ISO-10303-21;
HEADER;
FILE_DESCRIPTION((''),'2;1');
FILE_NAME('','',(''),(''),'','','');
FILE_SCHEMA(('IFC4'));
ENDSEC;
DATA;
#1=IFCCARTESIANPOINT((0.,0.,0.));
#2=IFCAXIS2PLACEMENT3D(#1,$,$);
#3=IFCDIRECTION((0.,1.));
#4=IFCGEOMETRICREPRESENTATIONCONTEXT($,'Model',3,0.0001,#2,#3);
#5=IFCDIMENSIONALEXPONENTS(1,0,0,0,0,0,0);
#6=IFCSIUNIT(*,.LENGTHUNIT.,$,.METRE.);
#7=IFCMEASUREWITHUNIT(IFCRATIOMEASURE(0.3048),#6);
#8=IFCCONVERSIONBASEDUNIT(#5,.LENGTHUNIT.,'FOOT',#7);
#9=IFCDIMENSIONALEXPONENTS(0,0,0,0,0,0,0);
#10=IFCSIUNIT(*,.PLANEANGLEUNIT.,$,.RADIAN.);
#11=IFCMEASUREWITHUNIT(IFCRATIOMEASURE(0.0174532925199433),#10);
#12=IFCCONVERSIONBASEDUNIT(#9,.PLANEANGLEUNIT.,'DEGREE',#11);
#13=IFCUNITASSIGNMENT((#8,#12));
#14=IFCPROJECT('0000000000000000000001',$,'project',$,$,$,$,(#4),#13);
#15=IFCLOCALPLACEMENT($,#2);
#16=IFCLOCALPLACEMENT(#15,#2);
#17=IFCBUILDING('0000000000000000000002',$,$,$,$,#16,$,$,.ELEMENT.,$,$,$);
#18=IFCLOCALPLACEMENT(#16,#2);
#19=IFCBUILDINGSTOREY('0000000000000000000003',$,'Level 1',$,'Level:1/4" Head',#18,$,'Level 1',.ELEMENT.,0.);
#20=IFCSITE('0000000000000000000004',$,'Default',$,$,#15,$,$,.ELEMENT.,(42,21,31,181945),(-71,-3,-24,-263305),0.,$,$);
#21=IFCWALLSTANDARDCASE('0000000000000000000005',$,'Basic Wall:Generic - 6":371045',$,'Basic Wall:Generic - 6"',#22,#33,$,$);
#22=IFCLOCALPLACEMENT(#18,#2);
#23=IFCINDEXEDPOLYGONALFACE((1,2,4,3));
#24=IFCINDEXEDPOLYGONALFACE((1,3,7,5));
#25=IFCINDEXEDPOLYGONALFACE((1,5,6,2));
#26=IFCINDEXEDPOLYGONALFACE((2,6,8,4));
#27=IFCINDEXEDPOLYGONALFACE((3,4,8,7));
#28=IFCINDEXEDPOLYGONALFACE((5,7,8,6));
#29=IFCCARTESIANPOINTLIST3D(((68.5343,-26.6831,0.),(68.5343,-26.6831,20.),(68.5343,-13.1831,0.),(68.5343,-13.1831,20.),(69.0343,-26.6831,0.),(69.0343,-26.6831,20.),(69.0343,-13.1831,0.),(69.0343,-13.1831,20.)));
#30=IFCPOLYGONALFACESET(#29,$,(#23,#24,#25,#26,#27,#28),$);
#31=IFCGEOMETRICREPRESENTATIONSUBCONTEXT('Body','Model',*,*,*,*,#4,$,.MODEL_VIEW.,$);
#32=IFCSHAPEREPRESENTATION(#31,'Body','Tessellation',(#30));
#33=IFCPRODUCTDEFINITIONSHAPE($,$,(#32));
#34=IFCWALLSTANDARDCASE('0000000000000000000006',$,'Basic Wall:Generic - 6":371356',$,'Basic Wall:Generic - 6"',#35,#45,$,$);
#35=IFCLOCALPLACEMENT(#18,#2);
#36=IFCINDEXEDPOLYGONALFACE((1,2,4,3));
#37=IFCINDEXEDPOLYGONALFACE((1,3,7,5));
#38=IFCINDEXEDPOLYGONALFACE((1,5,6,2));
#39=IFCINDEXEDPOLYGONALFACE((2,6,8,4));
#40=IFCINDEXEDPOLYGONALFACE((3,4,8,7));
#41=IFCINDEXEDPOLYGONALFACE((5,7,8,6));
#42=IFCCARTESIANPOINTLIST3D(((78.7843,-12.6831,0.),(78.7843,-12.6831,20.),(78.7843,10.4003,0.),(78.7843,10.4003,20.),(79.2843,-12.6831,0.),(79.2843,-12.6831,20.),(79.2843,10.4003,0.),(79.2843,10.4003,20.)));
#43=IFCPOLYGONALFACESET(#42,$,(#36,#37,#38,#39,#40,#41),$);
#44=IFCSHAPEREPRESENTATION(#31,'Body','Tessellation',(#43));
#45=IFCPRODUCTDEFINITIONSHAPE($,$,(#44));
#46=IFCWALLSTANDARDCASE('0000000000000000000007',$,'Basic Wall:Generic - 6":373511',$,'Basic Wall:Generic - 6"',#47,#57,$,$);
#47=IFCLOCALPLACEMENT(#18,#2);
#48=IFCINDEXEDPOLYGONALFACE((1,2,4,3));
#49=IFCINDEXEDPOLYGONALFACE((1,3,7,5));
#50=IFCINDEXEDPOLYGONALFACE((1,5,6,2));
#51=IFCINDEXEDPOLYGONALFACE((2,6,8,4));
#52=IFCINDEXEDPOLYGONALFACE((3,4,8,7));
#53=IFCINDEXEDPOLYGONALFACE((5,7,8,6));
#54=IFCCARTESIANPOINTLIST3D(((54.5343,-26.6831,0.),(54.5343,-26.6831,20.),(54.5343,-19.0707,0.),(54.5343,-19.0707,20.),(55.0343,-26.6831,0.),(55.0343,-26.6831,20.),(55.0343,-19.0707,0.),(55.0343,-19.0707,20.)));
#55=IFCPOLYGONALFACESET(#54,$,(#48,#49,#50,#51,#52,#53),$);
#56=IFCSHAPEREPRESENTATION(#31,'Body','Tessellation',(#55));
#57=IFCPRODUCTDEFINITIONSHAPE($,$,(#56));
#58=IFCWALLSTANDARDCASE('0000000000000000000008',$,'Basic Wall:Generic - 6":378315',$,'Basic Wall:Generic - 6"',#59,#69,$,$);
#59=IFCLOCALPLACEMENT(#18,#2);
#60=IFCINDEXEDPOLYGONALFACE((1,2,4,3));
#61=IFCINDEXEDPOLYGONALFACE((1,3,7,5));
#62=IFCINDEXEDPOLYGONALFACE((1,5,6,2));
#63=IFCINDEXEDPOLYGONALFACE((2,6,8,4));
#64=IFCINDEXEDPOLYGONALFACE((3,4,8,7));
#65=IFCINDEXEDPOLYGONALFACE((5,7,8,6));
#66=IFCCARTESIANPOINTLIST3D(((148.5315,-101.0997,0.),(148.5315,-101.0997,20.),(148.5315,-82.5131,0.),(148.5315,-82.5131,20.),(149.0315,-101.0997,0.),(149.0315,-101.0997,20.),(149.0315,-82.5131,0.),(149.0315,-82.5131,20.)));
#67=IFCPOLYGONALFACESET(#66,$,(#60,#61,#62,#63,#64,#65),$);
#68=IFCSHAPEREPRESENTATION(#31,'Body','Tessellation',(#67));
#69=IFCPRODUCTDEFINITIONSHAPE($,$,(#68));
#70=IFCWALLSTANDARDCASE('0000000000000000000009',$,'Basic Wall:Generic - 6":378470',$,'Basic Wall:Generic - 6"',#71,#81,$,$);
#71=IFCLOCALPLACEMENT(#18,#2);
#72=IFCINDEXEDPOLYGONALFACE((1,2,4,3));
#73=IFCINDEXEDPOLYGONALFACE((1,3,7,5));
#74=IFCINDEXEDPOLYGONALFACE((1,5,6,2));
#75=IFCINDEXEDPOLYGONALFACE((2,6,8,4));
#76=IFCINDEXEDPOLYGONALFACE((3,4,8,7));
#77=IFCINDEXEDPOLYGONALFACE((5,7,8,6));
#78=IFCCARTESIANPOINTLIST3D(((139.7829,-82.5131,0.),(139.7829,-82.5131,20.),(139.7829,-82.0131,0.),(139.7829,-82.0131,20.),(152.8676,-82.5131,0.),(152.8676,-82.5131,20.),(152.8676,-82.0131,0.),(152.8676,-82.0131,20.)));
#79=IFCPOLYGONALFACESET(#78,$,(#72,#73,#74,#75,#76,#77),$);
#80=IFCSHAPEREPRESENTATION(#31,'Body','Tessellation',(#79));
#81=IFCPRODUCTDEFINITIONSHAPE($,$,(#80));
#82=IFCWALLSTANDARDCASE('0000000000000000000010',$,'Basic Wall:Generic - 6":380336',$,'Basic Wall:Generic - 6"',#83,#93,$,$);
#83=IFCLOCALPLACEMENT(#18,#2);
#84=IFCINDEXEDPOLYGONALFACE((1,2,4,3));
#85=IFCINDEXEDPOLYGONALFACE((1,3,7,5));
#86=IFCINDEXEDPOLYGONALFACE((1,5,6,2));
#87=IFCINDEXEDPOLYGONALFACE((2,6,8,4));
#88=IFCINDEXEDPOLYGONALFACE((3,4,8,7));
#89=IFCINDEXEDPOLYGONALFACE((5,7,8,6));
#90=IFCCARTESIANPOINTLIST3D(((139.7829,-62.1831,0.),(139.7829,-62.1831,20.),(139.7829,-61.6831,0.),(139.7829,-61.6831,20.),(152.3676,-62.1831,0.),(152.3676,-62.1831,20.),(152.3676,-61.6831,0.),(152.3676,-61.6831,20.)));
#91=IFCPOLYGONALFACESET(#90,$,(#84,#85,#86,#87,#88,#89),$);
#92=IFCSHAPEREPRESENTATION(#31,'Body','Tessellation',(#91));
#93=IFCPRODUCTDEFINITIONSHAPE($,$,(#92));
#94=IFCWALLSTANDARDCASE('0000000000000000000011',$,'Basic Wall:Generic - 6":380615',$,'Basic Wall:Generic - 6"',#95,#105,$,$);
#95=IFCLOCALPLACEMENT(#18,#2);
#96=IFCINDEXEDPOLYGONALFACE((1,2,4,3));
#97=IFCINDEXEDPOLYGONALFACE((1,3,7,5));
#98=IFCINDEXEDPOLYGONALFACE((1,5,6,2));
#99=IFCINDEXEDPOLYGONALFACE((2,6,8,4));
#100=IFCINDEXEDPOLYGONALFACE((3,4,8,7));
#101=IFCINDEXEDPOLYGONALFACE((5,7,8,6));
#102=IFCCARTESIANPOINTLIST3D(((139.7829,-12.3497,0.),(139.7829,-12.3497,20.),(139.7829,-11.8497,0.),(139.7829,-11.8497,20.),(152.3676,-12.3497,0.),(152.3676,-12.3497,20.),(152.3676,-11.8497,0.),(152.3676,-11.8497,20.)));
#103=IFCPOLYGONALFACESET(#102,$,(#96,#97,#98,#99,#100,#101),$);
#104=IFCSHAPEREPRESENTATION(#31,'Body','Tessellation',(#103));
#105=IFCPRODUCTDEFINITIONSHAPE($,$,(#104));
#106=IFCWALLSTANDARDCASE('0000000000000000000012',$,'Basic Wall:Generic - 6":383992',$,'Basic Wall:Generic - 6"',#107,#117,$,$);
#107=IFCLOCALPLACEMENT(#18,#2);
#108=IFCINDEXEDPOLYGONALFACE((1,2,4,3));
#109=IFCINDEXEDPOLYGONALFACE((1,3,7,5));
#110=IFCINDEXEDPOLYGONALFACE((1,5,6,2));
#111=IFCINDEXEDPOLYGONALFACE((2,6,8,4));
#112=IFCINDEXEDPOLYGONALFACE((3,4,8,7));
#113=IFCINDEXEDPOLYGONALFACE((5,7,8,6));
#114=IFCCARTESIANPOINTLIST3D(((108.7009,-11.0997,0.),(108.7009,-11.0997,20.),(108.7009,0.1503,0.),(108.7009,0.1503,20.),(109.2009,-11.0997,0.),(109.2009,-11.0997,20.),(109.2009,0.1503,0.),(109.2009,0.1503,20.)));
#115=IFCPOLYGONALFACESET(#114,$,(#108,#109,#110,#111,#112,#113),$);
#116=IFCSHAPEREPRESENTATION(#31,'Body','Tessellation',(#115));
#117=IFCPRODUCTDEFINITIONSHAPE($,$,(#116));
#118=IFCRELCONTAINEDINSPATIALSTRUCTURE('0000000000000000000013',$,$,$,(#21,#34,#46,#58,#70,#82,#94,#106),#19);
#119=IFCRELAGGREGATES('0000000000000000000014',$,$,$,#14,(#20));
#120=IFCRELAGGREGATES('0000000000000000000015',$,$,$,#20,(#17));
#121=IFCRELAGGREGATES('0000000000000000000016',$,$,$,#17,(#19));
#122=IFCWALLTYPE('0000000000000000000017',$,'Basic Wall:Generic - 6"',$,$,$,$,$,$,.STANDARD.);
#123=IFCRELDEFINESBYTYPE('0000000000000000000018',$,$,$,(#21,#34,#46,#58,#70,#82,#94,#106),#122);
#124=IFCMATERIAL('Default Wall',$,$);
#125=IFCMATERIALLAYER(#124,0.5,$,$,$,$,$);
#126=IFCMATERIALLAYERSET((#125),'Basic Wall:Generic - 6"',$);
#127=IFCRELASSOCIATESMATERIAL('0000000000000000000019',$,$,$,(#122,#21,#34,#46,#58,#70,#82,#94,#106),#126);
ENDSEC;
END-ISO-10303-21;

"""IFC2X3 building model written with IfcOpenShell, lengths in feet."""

from ifc_helpers import new_model, entity, si_unit, converted_unit, direction, frame, frame_2d, origin, place, context, subcontext, project, spatial, rectangle, extrude, material, layer, layer_set, layer_usage, type_object, element, save


model = new_model("IFC2X3")

# Units and contexts
model_context = context("Model", 3, precision=0.0001, world=origin(), true_north=direction((0.0, 1.0)))
body_context = subcontext(model_context, "Body", "Model", "MODEL_VIEW")
ifc_project = project(units=[converted_unit("LENGTHUNIT", "FOOT", entity("IfcRatioMeasure", 0.3048), si_unit("LENGTHUNIT", "METRE"), dimensions=[1, 0, 0, 0, 0, 0, 0]), converted_unit("PLANEANGLEUNIT", "DEGREE", entity("IfcRatioMeasure", 0.0174532925199433), si_unit("PLANEANGLEUNIT", "RADIAN"), dimensions=[0, 0, 0, 0, 0, 0, 0])], contexts=[model_context])

# Site, building, storey
site_placement = place(None, origin())
site = spatial("IfcSite", under=ifc_project, at=site_placement, Name="Default", CompositionType="ELEMENT", RefLatitude=(42, 21, 31, 181945), RefLongitude=(-71, -3, -24, -263305), RefElevation=0.0)
building_placement = place(site_placement, origin())
building = spatial("IfcBuilding", under=site, at=building_placement, CompositionType="ELEMENT")
storey_placement = place(building_placement, origin())
storey = spatial("IfcBuildingStorey", under=building, at=storey_placement, Name="Level 1", ObjectType="Level:1/4\" Head", LongName="Level 1", CompositionType="ELEMENT", Elevation=0.0)

# Walls
ifc_material = material(Name="Default Wall")
ifc_layer_1 = layer(ifc_material, 0.5)
ifc_layer_set_1 = layer_set([ifc_layer_1], Name="Basic Wall:Generic - 6\"")
wall_type_1 = type_object("IfcWallType", Name="Basic Wall:Generic - 6\"", PredefinedType="STANDARD", material=ifc_layer_set_1)
ifc_layer_usage_1 = layer_usage(ifc_layer_set_1, "AXIS2", "NEGATIVE", 0.25)
wall_1_placement = place(storey_placement, frame((68.7843, -13.1831, 0.0), z_axis=(0.0, 0.0, 1.0), x_axis=(0.0, -1.0, 0.0)))
element("IfcWallStandardCase", 1, at=wall_1_placement, inside=storey, type_object=wall_type_1, material=ifc_layer_usage_1, Name="Basic Wall:Generic - 6\":371045", ObjectType="Basic Wall:Generic - 6\"", context=body_context, shape_type="SweptSolid", body=[
    extrude(rectangle(XDim=13.5, YDim=0.5, at=frame_2d((6.75, 0.0), x_axis=(-1.0, 0.0))), origin(), (0.0, 0.0, 1.0), 20.0),
])
ifc_layer_usage_2 = layer_usage(ifc_layer_set_1, "AXIS2", "NEGATIVE", 0.25)
wall_2_placement = place(storey_placement, frame((79.0343, -12.6831, 0.0), z_axis=(0.0, 0.0, 1.0), x_axis=(0.0, 1.0, 0.0)))
element("IfcWallStandardCase", 2, at=wall_2_placement, inside=storey, type_object=wall_type_1, material=ifc_layer_usage_2, Name="Basic Wall:Generic - 6\":371356", ObjectType="Basic Wall:Generic - 6\"", context=body_context, shape_type="SweptSolid", body=[
    extrude(rectangle(XDim=23.0833, YDim=0.5, at=frame_2d((11.5417, 0.0), x_axis=(-1.0, 0.0))), origin(), (0.0, 0.0, 1.0), 20.0),
])
ifc_layer_usage_3 = layer_usage(ifc_layer_set_1, "AXIS2", "NEGATIVE", 0.25)
wall_3_placement = place(storey_placement, frame((54.7843, -19.0707, 0.0), z_axis=(0.0, 0.0, 1.0), x_axis=(0.0, -1.0, 0.0)))
element("IfcWallStandardCase", 3, at=wall_3_placement, inside=storey, type_object=wall_type_1, material=ifc_layer_usage_3, Name="Basic Wall:Generic - 6\":373511", ObjectType="Basic Wall:Generic - 6\"", context=body_context, shape_type="SweptSolid", body=[
    extrude(rectangle(XDim=7.6123, YDim=0.5, at=frame_2d((3.8062, 0.0), x_axis=(-1.0, 0.0))), origin(), (0.0, 0.0, 1.0), 20.0),
])
ifc_layer_usage_4 = layer_usage(ifc_layer_set_1, "AXIS2", "NEGATIVE", 0.25)
wall_4_placement = place(storey_placement, frame((148.7815, -101.0997, 0.0), z_axis=(0.0, 0.0, 1.0), x_axis=(0.0, 1.0, 0.0)))
element("IfcWallStandardCase", 4, at=wall_4_placement, inside=storey, type_object=wall_type_1, material=ifc_layer_usage_4, Name="Basic Wall:Generic - 6\":378315", ObjectType="Basic Wall:Generic - 6\"", context=body_context, shape_type="SweptSolid", body=[
    extrude(rectangle(XDim=18.5867, YDim=0.5, at=frame_2d((9.2933, 0.0), x_axis=(-1.0, 0.0))), origin(), (0.0, 0.0, 1.0), 20.0),
])
ifc_layer_usage_5 = layer_usage(ifc_layer_set_1, "AXIS2", "NEGATIVE", 0.25)
wall_5_placement = place(storey_placement, frame((139.7829, -82.2631, 0.0)))
element("IfcWallStandardCase", 5, at=wall_5_placement, inside=storey, type_object=wall_type_1, material=ifc_layer_usage_5, Name="Basic Wall:Generic - 6\":378470", ObjectType="Basic Wall:Generic - 6\"", context=body_context, shape_type="SweptSolid", body=[
    extrude(rectangle(XDim=13.0847, YDim=0.5, at=frame_2d((6.5424, 0.0), x_axis=(-1.0, 0.0))), origin(), (0.0, 0.0, 1.0), 20.0),
])
ifc_layer_usage_6 = layer_usage(ifc_layer_set_1, "AXIS2", "NEGATIVE", 0.25)
wall_6_placement = place(storey_placement, frame((139.7829, -61.9331, 0.0)))
element("IfcWallStandardCase", 6, at=wall_6_placement, inside=storey, type_object=wall_type_1, material=ifc_layer_usage_6, Name="Basic Wall:Generic - 6\":380336", ObjectType="Basic Wall:Generic - 6\"", context=body_context, shape_type="SweptSolid", body=[
    extrude(rectangle(XDim=12.5847, YDim=0.5, at=frame_2d((6.2924, 0.0), x_axis=(-1.0, 0.0))), origin(), (0.0, 0.0, 1.0), 20.0),
])
ifc_layer_usage_7 = layer_usage(ifc_layer_set_1, "AXIS2", "NEGATIVE", 0.25)
wall_7_placement = place(storey_placement, frame((139.7829, -12.0997, 0.0)))
element("IfcWallStandardCase", 7, at=wall_7_placement, inside=storey, type_object=wall_type_1, material=ifc_layer_usage_7, Name="Basic Wall:Generic - 6\":380615", ObjectType="Basic Wall:Generic - 6\"", context=body_context, shape_type="SweptSolid", body=[
    extrude(rectangle(XDim=12.5847, YDim=0.5, at=frame_2d((6.2924, 0.0), x_axis=(-1.0, 0.0))), origin(), (0.0, 0.0, 1.0), 20.0),
])
ifc_layer_usage_8 = layer_usage(ifc_layer_set_1, "AXIS2", "NEGATIVE", 0.25)
wall_8_placement = place(storey_placement, frame((108.9509, -11.0997, 0.0), z_axis=(0.0, 0.0, 1.0), x_axis=(0.0, 1.0, 0.0)))
element("IfcWallStandardCase", 8, at=wall_8_placement, inside=storey, type_object=wall_type_1, material=ifc_layer_usage_8, Name="Basic Wall:Generic - 6\":383992", ObjectType="Basic Wall:Generic - 6\"", context=body_context, shape_type="SweptSolid", body=[
    extrude(rectangle(XDim=11.25, YDim=0.5, at=frame_2d((5.625, 0.0), x_axis=(-1.0, 0.0))), origin(), (0.0, 0.0, 1.0), 20.0),
])

save(model, "model.ifc")
